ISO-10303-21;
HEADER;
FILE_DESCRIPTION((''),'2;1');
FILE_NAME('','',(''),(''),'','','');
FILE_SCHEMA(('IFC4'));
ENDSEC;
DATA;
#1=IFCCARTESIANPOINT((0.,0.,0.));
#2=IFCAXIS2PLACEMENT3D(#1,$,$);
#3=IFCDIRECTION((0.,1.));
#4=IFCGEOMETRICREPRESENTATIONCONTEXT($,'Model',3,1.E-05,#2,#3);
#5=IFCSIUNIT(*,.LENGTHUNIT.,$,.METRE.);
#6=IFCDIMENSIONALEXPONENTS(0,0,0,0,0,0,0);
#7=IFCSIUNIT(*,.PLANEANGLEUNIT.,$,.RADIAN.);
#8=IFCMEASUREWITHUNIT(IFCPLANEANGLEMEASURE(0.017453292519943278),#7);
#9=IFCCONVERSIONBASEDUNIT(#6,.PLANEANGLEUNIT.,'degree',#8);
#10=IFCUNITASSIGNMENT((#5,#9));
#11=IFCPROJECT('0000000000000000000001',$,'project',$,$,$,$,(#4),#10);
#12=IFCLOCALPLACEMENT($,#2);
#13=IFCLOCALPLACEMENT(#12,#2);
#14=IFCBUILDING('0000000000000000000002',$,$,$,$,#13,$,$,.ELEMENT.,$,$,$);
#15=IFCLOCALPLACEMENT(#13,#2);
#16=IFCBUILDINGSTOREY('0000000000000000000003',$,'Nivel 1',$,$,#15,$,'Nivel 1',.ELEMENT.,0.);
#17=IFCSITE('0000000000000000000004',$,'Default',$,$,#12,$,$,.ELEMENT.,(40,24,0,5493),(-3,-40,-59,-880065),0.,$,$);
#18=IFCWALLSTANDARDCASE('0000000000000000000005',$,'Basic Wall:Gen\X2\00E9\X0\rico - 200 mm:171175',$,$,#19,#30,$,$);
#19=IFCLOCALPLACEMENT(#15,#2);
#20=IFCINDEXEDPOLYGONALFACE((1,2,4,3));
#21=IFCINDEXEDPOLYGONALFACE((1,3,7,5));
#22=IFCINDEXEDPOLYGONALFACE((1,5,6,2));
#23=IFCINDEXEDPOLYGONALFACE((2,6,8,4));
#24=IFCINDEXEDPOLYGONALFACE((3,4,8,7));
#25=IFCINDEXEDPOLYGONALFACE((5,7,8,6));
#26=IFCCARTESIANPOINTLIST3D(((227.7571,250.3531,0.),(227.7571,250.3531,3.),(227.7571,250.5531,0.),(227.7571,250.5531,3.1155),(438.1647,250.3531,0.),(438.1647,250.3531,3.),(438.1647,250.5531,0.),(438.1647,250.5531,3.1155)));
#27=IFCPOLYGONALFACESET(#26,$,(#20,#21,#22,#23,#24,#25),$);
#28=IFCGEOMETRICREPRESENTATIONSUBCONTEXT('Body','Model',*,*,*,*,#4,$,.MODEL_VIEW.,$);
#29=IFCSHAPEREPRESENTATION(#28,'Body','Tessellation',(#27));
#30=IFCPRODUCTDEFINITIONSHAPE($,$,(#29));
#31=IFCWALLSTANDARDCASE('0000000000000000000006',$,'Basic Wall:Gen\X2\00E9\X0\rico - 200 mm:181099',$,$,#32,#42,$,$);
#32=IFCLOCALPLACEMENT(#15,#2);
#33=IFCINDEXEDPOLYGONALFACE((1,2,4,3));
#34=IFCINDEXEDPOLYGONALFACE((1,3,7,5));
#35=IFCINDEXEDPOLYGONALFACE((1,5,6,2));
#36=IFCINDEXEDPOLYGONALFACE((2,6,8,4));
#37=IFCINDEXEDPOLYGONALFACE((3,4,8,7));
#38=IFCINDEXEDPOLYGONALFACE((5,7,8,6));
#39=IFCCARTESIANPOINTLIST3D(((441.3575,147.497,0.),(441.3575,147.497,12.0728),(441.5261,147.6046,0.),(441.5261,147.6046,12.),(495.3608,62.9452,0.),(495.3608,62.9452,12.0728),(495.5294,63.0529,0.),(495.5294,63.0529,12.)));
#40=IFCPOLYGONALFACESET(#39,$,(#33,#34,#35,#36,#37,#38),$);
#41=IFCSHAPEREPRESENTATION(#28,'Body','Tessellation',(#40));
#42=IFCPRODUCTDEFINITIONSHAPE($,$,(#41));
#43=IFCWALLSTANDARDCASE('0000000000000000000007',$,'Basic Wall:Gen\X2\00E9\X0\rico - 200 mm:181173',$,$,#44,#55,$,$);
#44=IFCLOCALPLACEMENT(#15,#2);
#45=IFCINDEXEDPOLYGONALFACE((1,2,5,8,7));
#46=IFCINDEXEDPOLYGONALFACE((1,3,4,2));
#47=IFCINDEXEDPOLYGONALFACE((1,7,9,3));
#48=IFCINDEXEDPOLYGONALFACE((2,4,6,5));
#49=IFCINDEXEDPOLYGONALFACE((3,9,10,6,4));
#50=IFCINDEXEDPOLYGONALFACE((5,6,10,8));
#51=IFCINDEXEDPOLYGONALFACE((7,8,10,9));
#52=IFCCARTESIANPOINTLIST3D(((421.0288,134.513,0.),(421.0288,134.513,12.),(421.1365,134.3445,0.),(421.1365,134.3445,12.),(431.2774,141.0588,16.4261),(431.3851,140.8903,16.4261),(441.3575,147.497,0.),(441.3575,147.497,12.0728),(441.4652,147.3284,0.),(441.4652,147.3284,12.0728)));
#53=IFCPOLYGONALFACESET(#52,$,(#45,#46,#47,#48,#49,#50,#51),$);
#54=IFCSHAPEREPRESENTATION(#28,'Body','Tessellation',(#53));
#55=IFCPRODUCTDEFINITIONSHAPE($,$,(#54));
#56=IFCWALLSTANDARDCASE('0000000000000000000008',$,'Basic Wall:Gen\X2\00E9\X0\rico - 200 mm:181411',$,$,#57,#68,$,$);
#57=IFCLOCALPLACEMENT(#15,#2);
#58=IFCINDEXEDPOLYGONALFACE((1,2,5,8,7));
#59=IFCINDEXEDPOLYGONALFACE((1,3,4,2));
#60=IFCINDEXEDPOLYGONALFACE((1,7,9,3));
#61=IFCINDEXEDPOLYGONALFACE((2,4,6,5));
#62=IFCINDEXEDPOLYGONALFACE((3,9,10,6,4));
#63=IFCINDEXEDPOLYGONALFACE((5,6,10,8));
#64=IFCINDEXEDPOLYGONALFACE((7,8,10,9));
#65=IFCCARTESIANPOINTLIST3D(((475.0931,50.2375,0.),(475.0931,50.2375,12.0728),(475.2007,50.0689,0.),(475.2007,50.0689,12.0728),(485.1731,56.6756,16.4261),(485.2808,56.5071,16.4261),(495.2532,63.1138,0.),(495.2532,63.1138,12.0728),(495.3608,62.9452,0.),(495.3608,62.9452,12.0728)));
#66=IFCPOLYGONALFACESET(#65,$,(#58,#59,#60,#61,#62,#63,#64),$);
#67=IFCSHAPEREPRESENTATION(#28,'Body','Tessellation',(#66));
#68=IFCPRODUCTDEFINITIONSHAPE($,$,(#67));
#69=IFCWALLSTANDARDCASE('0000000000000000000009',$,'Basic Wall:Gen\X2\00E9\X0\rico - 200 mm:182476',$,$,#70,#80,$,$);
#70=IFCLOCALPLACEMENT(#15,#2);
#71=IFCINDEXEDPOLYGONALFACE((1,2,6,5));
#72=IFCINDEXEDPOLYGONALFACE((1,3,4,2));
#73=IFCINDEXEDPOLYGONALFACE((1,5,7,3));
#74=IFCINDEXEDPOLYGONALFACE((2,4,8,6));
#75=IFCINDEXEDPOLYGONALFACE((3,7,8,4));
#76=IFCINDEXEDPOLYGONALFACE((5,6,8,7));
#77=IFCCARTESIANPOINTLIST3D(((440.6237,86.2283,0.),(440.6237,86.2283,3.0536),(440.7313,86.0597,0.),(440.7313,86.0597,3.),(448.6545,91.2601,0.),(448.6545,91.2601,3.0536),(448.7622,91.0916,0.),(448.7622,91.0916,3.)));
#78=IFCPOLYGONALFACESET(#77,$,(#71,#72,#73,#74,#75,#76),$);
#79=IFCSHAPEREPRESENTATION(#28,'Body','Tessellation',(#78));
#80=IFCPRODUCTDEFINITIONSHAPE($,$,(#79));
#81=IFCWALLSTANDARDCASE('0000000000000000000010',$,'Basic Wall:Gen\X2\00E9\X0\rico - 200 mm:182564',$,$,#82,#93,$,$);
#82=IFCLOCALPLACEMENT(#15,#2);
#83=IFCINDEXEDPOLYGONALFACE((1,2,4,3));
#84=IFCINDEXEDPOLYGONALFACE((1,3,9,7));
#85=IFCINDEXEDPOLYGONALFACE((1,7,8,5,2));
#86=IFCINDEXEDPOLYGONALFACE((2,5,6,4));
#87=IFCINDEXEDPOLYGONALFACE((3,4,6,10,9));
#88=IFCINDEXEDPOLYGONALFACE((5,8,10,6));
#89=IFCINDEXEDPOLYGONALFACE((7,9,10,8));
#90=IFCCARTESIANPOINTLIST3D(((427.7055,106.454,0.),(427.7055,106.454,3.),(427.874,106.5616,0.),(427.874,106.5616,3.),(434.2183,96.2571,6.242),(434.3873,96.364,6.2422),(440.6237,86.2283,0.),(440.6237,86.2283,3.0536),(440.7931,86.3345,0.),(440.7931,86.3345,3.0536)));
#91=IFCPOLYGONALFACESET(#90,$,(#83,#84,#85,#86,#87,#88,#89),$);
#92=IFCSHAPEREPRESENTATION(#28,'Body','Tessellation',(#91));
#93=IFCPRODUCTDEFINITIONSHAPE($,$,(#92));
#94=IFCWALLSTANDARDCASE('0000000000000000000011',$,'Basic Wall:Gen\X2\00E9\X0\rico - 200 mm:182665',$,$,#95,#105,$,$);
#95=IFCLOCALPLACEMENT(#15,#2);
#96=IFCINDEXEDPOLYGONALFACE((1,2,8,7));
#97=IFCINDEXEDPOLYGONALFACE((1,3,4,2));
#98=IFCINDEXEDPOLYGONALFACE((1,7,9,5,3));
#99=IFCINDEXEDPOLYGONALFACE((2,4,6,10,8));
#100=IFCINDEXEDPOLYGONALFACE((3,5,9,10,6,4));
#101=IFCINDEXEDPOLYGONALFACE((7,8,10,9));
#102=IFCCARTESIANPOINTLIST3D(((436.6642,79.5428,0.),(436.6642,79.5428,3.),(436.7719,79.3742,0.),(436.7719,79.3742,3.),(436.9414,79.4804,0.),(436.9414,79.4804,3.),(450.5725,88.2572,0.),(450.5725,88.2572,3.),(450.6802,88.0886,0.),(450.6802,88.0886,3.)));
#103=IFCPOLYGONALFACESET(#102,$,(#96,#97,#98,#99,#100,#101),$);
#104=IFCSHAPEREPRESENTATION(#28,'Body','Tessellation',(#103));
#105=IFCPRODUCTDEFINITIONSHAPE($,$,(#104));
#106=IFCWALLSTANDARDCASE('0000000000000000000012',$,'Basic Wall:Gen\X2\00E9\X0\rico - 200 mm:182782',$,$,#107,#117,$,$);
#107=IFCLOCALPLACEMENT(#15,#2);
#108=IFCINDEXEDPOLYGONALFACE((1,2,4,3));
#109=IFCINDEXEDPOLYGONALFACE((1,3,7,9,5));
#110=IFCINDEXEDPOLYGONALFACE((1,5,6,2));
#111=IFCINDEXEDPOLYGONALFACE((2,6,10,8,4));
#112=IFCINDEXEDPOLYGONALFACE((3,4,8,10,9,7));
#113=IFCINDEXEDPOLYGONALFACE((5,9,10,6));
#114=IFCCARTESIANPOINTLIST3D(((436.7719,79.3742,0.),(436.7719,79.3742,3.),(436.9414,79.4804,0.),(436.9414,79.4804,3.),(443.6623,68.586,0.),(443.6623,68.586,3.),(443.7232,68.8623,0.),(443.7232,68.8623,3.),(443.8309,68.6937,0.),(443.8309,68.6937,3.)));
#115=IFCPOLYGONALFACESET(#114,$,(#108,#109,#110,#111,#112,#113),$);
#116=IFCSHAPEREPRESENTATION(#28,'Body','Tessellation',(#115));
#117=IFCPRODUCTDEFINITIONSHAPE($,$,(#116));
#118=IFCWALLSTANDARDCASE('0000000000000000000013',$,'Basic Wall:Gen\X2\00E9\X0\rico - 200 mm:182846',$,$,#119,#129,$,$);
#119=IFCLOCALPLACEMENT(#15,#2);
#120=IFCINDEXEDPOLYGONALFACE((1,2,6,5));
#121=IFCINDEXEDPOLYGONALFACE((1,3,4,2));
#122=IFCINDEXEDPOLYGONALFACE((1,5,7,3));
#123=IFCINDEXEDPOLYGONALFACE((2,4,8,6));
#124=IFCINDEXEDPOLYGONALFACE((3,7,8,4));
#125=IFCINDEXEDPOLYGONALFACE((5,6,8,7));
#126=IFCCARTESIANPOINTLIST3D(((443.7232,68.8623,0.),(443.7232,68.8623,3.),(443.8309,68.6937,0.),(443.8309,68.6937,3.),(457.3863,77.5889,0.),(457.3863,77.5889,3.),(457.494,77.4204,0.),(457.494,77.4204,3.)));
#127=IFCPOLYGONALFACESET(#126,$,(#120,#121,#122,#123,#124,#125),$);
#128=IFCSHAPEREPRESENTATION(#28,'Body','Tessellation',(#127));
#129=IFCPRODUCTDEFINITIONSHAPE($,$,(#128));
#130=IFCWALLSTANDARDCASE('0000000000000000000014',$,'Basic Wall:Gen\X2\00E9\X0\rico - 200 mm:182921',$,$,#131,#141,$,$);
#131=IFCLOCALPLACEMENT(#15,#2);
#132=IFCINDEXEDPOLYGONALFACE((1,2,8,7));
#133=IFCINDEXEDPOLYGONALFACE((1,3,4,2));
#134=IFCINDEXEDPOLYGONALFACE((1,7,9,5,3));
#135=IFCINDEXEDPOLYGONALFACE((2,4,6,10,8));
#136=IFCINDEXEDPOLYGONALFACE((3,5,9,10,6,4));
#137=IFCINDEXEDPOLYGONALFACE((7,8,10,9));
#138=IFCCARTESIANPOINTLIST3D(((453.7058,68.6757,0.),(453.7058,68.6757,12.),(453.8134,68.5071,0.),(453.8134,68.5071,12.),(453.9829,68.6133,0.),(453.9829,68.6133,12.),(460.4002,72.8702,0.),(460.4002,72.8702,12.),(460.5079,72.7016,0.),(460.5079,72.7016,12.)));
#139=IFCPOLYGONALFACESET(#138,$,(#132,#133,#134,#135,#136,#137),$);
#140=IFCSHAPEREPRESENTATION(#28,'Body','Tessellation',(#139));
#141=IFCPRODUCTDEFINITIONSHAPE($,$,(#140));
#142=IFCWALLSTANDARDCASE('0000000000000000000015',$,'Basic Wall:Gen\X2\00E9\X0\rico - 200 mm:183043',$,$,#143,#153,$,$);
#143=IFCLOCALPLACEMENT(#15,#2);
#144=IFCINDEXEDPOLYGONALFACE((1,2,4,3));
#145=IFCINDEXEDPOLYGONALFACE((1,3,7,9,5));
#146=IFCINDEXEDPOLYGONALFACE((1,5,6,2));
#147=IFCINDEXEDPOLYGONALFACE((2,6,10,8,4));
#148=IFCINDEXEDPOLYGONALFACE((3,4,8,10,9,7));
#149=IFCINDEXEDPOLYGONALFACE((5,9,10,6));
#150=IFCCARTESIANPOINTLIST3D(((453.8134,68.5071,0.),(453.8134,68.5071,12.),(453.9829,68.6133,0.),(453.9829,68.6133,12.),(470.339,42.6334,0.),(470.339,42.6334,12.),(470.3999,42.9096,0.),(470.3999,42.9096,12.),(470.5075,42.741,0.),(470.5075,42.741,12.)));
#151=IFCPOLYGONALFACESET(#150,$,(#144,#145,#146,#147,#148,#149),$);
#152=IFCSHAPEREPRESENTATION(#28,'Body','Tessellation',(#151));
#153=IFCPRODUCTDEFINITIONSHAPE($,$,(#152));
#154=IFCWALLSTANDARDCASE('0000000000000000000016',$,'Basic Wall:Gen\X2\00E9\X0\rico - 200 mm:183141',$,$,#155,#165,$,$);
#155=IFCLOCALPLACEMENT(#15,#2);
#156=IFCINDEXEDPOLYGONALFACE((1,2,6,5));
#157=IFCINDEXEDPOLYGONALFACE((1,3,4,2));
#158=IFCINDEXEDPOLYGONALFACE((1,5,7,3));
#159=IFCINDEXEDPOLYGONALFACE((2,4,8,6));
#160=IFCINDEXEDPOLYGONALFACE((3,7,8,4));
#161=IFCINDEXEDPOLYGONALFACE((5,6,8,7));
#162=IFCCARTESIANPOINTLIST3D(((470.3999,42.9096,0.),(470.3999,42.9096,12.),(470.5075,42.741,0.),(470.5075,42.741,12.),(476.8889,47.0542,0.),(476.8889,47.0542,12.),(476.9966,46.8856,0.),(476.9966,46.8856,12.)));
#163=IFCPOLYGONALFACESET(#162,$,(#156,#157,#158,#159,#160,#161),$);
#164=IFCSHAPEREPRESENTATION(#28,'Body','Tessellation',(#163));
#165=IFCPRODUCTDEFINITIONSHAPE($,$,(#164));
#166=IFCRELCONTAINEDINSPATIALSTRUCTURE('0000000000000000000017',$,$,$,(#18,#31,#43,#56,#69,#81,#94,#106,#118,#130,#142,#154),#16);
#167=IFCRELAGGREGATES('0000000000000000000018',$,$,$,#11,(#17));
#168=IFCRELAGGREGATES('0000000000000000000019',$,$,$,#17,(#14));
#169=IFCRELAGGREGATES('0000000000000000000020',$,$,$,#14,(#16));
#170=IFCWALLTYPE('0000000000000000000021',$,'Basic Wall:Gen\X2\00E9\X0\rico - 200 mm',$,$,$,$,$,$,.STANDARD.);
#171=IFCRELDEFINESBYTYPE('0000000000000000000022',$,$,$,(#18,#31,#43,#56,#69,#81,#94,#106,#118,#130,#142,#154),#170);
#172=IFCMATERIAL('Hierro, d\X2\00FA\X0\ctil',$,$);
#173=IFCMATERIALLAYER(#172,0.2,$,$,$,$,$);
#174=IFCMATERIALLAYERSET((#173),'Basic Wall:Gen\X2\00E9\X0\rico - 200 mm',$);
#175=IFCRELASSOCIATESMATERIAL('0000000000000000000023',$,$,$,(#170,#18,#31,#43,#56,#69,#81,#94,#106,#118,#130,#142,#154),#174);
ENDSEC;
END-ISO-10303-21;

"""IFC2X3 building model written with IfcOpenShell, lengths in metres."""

from ifc_helpers import new_model, entity, si_unit, converted_unit, direction, frame, frame_2d, origin, place, context, subcontext, project, spatial, polyline, rectangle, outline, extrude, clip, bounded_halfspace, material, layer, layer_set, layer_usage, type_object, element, save


model = new_model("IFC2X3")

# Units and contexts
model_context = context("Model", 3, precision=1e-05, world=origin(), true_north=direction((0.0, 1.0)))
body_context = subcontext(model_context, "Body", "Model", "MODEL_VIEW")
ifc_project = project(units=[si_unit("LENGTHUNIT", "METRE"), converted_unit("PLANEANGLEUNIT", "degree", entity("IfcPlaneAngleMeasure", 0.017453292519943278), si_unit("PLANEANGLEUNIT", "RADIAN"), dimensions=[0, 0, 0, 0, 0, 0, 0])], contexts=[model_context])

# Site, building, storey
site_placement = place(None, origin())
site = spatial("IfcSite", under=ifc_project, at=site_placement, Name="Default", CompositionType="ELEMENT", RefLatitude=(40, 24, 0, 5493), RefLongitude=(-3, -40, -59, -880065), RefElevation=0.0)
building_placement = place(site_placement, origin())
building = spatial("IfcBuilding", under=site, at=building_placement, CompositionType="ELEMENT")
storey_placement = place(building_placement, origin())
storey = spatial("IfcBuildingStorey", under=building, at=storey_placement, Name="Nivel 1", LongName="Nivel 1", CompositionType="ELEMENT", Elevation=0.0)

# Walls
ifc_material_1 = material(Name="Hierro, dúctil")
ifc_layer_1 = layer(ifc_material_1, 0.2)
ifc_layer_set_1 = layer_set([ifc_layer_1], Name="Basic Wall:Genérico - 200 mm")
wall_type = type_object("IfcWallType", Name="Basic Wall:Genérico - 200 mm", PredefinedType="STANDARD", material=ifc_layer_set_1)
ifc_layer_usage_1 = layer_usage(ifc_layer_set_1, "AXIS2", "NEGATIVE", 0.1)
wall_1_placement = place(storey_placement, frame((438.1647, 250.4531, 0.0), z_axis=(0.0, 0.0, 1.0), x_axis=(-1.0, 0.0, 0.0)))
element("IfcWallStandardCase", 1, at=wall_1_placement, inside=storey, type_object=wall_type, material=ifc_layer_usage_1, Name="Basic Wall:Genérico - 200 mm:171175", context=body_context, shape_type="Clipping", body=[
    clip(extrude(rectangle(XDim=210.4076, YDim=0.2, at=frame_2d((105.2038, 0.0), x_axis=(-1.0, 0.0))), origin(), (0.0, 0.0, 1.0), 3.1155), bounded_halfspace(frame((0.0, -0.1, 3.1155), z_axis=(0.0, 0.5, 0.866025), x_axis=(-1.0, 0.0, 0.0)), False, frame((0.0, -0.1, 3.1155)), polyline([(0.0, 0.0), (210.2076, 0.0), (210.4076, 0.0), (210.4076, 0.2), (0.0, 0.2), (0.0, 0.0)]))),
])
ifc_layer_usage_2 = layer_usage(ifc_layer_set_1, "AXIS2", "NEGATIVE", 0.1)
wall_2_placement = place(storey_placement, frame((495.4451, 62.9991, 0.0), z_axis=(0.0, 0.0, 1.0), x_axis=(-0.538277, 0.842768, 0.0)))
element("IfcWallStandardCase", 2, at=wall_2_placement, inside=storey, type_object=wall_type, material=ifc_layer_usage_2, Name="Basic Wall:Genérico - 200 mm:181099", context=body_context, shape_type="Clipping", body=[
    clip(extrude(rectangle(XDim=100.3262, YDim=0.2, at=frame_2d((50.1631, 0.0), x_axis=(-1.0, 0.0))), origin(), (0.0, 0.0, 1.0), 12.0728), bounded_halfspace(frame((0.0, -0.1, 12.0), z_axis=(0.0, -0.34202, 0.939693), x_axis=(1.0, 0.0, 0.0)), False, frame((0.0, -0.1, 12.0)), polyline([(0.0, 0.0), (100.3262, 0.0), (100.3262, 0.2), (100.1262, 0.2), (0.2, 0.2), (0.0, 0.2), (0.0, 0.0)]))),
])
ifc_layer_usage_3 = layer_usage(ifc_layer_set_1, "AXIS2", "NEGATIVE", 0.1)
wall_3_placement = place(storey_placement, frame((441.4113, 147.4127, 0.0), z_axis=(0.0, 0.0, 1.0), x_axis=(-0.842768, -0.538277, 0.0)))
element("IfcWallStandardCase", 3, at=wall_3_placement, inside=storey, type_object=wall_type, material=ifc_layer_usage_3, Name="Basic Wall:Genérico - 200 mm:181173", context=body_context, shape_type="Clipping", body=[
    clip(clip(extrude(rectangle(XDim=24.1213, YDim=0.2, at=frame_2d((12.0606, 0.0), x_axis=(-1.0, 0.0))), origin(), (0.0, 0.0, 1.0), 16.4261), bounded_halfspace(frame((11.9606, -0.1, 16.4261), z_axis=(0.34202, 0.0, 0.939693), x_axis=(0.0, 1.0, 0.0)), False, frame((11.9606, -0.1, 16.4261)), polyline([(0.0, 0.0), (12.1606, 0.0), (12.1606, 0.2), (0.0, 0.2), (0.0, 0.0)]))), bounded_halfspace(frame((0.0, -0.1, 12.0728), z_axis=(-0.34202, 0.0, 0.939693), x_axis=(0.0, -1.0, 0.0)), False, frame((0.0, -0.1, 12.0728)), polyline([(0.0, 0.0), (11.9606, 0.0), (11.9606, 0.2), (0.0, 0.2), (0.0, 0.0)]))),
])
ifc_layer_usage_4 = layer_usage(ifc_layer_set_1, "AXIS2", "NEGATIVE", 0.1)
wall_4_placement = place(storey_placement, frame((475.1469, 50.1532, 0.0), z_axis=(0.0, 0.0, 1.0), x_axis=(0.842768, 0.538277, 0.0)))
element("IfcWallStandardCase", 4, at=wall_4_placement, inside=storey, type_object=wall_type, material=ifc_layer_usage_4, Name="Basic Wall:Genérico - 200 mm:181411", context=body_context, shape_type="Clipping", body=[
    clip(clip(extrude(rectangle(XDim=23.9213, YDim=0.2, at=frame_2d((11.9606, 0.0), x_axis=(-1.0, 0.0))), origin(), (0.0, 0.0, 1.0), 16.4261), bounded_halfspace(frame((0.0, -0.1, 12.0728), z_axis=(-0.34202, 0.0, 0.939693), x_axis=(0.0, -1.0, 0.0)), False, frame((0.0, -0.1, 12.0728)), polyline([(0.0, 0.0), (11.9606, 0.0), (11.9606, 0.2), (0.0, 0.2), (0.0, 0.0)]))), bounded_halfspace(frame((11.9606, -0.1, 16.4261), z_axis=(0.34202, 0.0, 0.939693), x_axis=(0.0, 1.0, 0.0)), False, frame((11.9606, -0.1, 16.4261)), polyline([(0.0, 0.0), (11.9606, 0.0), (11.9606, 0.2), (0.0, 0.2), (0.0, 0.0)]))),
])
ifc_layer_usage_5 = layer_usage(ifc_layer_set_1, "AXIS2", "NEGATIVE", 0.1)
wall_5_placement = place(storey_placement, frame((448.7091, 91.1763, 0.0), z_axis=(0.0, 0.0, 1.0), x_axis=(-0.847403, -0.530951, 0.0)))
element("IfcWallStandardCase", 5, at=wall_5_placement, inside=storey, type_object=wall_type, material=ifc_layer_usage_5, Name="Basic Wall:Genérico - 200 mm:182476", context=body_context, shape_type="Clipping", body=[
    clip(extrude(outline(polyline([(9.4788, -0.1), (9.477, 0.1), (0.0, 0.1), (0.0017, -0.1), (9.2788, -0.1), (9.4788, -0.1)])), origin(), (0.0, 0.0, 1.0), 3.0536), bounded_halfspace(frame((0.0017, -0.1, 3.0536), z_axis=(0.0, 0.258819, 0.965926), x_axis=(-1.0, 0.0, 0.0)), False, frame((0.0017, -0.1, 3.0536)), polyline([(0.0, 0.0), (9.277, 0.0), (9.477, 0.0), (9.4753, 0.2), (-0.0017, 0.2), (0.0, 0.0)]))),
])
ifc_layer_usage_6 = layer_usage(ifc_layer_set_1, "AXIS2", "NEGATIVE", 0.1)
wall_6_placement = place(storey_placement, frame((440.7089, 86.2807, 0.0), z_axis=(0.0, 0.0, 1.0), x_axis=(-0.538277, 0.842768, 0.0)))
element("IfcWallStandardCase", 6, at=wall_6_placement, inside=storey, type_object=wall_type, material=ifc_layer_usage_6, Name="Basic Wall:Genérico - 200 mm:182564", context=body_context, shape_type="Clipping", body=[
    clip(clip(extrude(outline(polyline([(24.0009, -0.1), (24.0009, 0.1), (0.0017, 0.1), (0.0, -0.1), (23.8009, -0.1), (24.0009, -0.1)])), origin(), (0.0, 0.0, 1.0), 6.2422), bounded_halfspace(frame((11.9007, -0.1, 6.2422), z_axis=(0.258819, 0.0, 0.965926), x_axis=(0.0, 1.0, 0.0)), False, frame((11.9007, -0.1, 6.2422)), polyline([(0.0, 0.0), (11.9002, 0.0), (12.1002, 0.0), (12.1002, 0.2), (0.0009, 0.2), (0.0, 0.0)]))), bounded_halfspace(frame((0.0, -0.1, 3.0536), z_axis=(-0.258809, 0.002244, 0.965926), x_axis=(-0.008669, -0.999962, 0.0)), False, frame((0.0, -0.1, 3.0536)), polyline([(0.0, 0.0), (11.9007, 0.0), (11.9015, 0.2), (0.0017, 0.2), (0.0, 0.0)]))),
])
ifc_layer_usage_7 = layer_usage(ifc_layer_set_1, "AXIS2", "NEGATIVE", 0.1)
wall_7_placement = place(storey_placement, frame((450.6271, 88.1734, 0.0), z_axis=(0.0, 0.0, 1.0), x_axis=(-0.847403, -0.530951, 0.0)))
element("IfcWallStandardCase", 7, at=wall_7_placement, inside=storey, type_object=wall_type, material=ifc_layer_usage_7, Name="Basic Wall:Genérico - 200 mm:182665", context=body_context, shape_type="SweptSolid", body=[
    extrude(outline(polyline([(16.4146, -0.1), (16.4128, 0.1), (16.2128, 0.1), (0.0, 0.1), (0.0017, -0.1), (16.4146, -0.1)])), origin(), (0.0, 0.0, 1.0), 3.0),
])
ifc_layer_usage_8 = layer_usage(ifc_layer_set_1, "AXIS2", "NEGATIVE", 0.1)
wall_8_placement = place(storey_placement, frame((436.8562, 79.428, 0.0), z_axis=(0.0, 0.0, 1.0), x_axis=(0.538277, -0.842768, 0.0)))
element("IfcWallStandardCase", 8, at=wall_8_placement, inside=storey, type_object=wall_type, material=ifc_layer_usage_8, Name="Basic Wall:Genérico - 200 mm:182782", context=body_context, shape_type="SweptSolid", body=[
    extrude(outline(polyline([(12.8009, -0.1), (12.8009, 0.1), (12.6009, 0.1), (0.0017, 0.1), (0.0, -0.1), (12.8009, -0.1)])), origin(), (0.0, 0.0, 1.0), 3.0),
])
ifc_layer_usage_9 = layer_usage(ifc_layer_set_1, "AXIS2", "NEGATIVE", 0.1)
wall_9_placement = place(storey_placement, frame((443.777, 68.778, 0.0), z_axis=(0.0, 0.0, 1.0), x_axis=(0.842768, 0.538277, 0.0)))
element("IfcWallStandardCase", 9, at=wall_9_placement, inside=storey, type_object=wall_type, material=ifc_layer_usage_9, Name="Basic Wall:Genérico - 200 mm:182846", context=body_context, shape_type="SweptSolid", body=[
    extrude(rectangle(XDim=16.2122, YDim=0.2, at=frame_2d((8.1061, 0.0), x_axis=(-1.0, 0.0))), origin(), (0.0, 0.0, 1.0), 3.0),
])
ifc_layer_usage_10 = layer_usage(ifc_layer_set_1, "AXIS2", "NEGATIVE", 0.1)
wall_10_placement = place(storey_placement, frame((460.4548, 72.7863, 0.0), z_axis=(0.0, 0.0, 1.0), x_axis=(-0.847403, -0.530951, 0.0)))
element("IfcWallStandardCase", 10, at=wall_10_placement, inside=storey, type_object=wall_type, material=ifc_layer_usage_10, Name="Basic Wall:Genérico - 200 mm:182921", context=body_context, shape_type="SweptSolid", body=[
    extrude(outline(polyline([(7.9017, -0.1), (7.9, 0.1), (7.7, 0.1), (0.0, 0.1), (0.0017, -0.1), (7.9017, -0.1)])), origin(), (0.0, 0.0, 1.0), 12.0),
])
ifc_layer_usage_11 = layer_usage(ifc_layer_set_1, "AXIS2", "NEGATIVE", 0.1)
wall_11_placement = place(storey_placement, frame((453.8977, 68.5609, 0.0), z_axis=(0.0, 0.0, 1.0), x_axis=(0.538277, -0.842768, 0.0)))
element("IfcWallStandardCase", 11, at=wall_11_placement, inside=storey, type_object=wall_type, material=ifc_layer_usage_11, Name="Basic Wall:Genérico - 200 mm:183043", context=body_context, shape_type="SweptSolid", body=[
    extrude(outline(polyline([(30.7009, -0.1), (30.7009, 0.1), (30.5009, 0.1), (0.0017, 0.1), (0.0, -0.1), (30.7009, -0.1)])), origin(), (0.0, 0.0, 1.0), 12.0),
])
ifc_layer_usage_12 = layer_usage(ifc_layer_set_1, "AXIS2", "NEGATIVE", 0.1)
wall_12_placement = place(storey_placement, frame((470.4537, 42.8253, 0.0), z_axis=(0.0, 0.0, 1.0), x_axis=(0.842768, 0.538277, 0.0)))
element("IfcWallStandardCase", 12, at=wall_12_placement, inside=storey, type_object=wall_type, material=ifc_layer_usage_12, Name="Basic Wall:Genérico - 200 mm:183141", context=body_context, shape_type="SweptSolid", body=[
    extrude(rectangle(XDim=7.6997, YDim=0.2, at=frame_2d((3.8499, 0.0), x_axis=(-1.0, 0.0))), origin(), (0.0, 0.0, 1.0), 12.0),
])

save(model, "model.ifc")
